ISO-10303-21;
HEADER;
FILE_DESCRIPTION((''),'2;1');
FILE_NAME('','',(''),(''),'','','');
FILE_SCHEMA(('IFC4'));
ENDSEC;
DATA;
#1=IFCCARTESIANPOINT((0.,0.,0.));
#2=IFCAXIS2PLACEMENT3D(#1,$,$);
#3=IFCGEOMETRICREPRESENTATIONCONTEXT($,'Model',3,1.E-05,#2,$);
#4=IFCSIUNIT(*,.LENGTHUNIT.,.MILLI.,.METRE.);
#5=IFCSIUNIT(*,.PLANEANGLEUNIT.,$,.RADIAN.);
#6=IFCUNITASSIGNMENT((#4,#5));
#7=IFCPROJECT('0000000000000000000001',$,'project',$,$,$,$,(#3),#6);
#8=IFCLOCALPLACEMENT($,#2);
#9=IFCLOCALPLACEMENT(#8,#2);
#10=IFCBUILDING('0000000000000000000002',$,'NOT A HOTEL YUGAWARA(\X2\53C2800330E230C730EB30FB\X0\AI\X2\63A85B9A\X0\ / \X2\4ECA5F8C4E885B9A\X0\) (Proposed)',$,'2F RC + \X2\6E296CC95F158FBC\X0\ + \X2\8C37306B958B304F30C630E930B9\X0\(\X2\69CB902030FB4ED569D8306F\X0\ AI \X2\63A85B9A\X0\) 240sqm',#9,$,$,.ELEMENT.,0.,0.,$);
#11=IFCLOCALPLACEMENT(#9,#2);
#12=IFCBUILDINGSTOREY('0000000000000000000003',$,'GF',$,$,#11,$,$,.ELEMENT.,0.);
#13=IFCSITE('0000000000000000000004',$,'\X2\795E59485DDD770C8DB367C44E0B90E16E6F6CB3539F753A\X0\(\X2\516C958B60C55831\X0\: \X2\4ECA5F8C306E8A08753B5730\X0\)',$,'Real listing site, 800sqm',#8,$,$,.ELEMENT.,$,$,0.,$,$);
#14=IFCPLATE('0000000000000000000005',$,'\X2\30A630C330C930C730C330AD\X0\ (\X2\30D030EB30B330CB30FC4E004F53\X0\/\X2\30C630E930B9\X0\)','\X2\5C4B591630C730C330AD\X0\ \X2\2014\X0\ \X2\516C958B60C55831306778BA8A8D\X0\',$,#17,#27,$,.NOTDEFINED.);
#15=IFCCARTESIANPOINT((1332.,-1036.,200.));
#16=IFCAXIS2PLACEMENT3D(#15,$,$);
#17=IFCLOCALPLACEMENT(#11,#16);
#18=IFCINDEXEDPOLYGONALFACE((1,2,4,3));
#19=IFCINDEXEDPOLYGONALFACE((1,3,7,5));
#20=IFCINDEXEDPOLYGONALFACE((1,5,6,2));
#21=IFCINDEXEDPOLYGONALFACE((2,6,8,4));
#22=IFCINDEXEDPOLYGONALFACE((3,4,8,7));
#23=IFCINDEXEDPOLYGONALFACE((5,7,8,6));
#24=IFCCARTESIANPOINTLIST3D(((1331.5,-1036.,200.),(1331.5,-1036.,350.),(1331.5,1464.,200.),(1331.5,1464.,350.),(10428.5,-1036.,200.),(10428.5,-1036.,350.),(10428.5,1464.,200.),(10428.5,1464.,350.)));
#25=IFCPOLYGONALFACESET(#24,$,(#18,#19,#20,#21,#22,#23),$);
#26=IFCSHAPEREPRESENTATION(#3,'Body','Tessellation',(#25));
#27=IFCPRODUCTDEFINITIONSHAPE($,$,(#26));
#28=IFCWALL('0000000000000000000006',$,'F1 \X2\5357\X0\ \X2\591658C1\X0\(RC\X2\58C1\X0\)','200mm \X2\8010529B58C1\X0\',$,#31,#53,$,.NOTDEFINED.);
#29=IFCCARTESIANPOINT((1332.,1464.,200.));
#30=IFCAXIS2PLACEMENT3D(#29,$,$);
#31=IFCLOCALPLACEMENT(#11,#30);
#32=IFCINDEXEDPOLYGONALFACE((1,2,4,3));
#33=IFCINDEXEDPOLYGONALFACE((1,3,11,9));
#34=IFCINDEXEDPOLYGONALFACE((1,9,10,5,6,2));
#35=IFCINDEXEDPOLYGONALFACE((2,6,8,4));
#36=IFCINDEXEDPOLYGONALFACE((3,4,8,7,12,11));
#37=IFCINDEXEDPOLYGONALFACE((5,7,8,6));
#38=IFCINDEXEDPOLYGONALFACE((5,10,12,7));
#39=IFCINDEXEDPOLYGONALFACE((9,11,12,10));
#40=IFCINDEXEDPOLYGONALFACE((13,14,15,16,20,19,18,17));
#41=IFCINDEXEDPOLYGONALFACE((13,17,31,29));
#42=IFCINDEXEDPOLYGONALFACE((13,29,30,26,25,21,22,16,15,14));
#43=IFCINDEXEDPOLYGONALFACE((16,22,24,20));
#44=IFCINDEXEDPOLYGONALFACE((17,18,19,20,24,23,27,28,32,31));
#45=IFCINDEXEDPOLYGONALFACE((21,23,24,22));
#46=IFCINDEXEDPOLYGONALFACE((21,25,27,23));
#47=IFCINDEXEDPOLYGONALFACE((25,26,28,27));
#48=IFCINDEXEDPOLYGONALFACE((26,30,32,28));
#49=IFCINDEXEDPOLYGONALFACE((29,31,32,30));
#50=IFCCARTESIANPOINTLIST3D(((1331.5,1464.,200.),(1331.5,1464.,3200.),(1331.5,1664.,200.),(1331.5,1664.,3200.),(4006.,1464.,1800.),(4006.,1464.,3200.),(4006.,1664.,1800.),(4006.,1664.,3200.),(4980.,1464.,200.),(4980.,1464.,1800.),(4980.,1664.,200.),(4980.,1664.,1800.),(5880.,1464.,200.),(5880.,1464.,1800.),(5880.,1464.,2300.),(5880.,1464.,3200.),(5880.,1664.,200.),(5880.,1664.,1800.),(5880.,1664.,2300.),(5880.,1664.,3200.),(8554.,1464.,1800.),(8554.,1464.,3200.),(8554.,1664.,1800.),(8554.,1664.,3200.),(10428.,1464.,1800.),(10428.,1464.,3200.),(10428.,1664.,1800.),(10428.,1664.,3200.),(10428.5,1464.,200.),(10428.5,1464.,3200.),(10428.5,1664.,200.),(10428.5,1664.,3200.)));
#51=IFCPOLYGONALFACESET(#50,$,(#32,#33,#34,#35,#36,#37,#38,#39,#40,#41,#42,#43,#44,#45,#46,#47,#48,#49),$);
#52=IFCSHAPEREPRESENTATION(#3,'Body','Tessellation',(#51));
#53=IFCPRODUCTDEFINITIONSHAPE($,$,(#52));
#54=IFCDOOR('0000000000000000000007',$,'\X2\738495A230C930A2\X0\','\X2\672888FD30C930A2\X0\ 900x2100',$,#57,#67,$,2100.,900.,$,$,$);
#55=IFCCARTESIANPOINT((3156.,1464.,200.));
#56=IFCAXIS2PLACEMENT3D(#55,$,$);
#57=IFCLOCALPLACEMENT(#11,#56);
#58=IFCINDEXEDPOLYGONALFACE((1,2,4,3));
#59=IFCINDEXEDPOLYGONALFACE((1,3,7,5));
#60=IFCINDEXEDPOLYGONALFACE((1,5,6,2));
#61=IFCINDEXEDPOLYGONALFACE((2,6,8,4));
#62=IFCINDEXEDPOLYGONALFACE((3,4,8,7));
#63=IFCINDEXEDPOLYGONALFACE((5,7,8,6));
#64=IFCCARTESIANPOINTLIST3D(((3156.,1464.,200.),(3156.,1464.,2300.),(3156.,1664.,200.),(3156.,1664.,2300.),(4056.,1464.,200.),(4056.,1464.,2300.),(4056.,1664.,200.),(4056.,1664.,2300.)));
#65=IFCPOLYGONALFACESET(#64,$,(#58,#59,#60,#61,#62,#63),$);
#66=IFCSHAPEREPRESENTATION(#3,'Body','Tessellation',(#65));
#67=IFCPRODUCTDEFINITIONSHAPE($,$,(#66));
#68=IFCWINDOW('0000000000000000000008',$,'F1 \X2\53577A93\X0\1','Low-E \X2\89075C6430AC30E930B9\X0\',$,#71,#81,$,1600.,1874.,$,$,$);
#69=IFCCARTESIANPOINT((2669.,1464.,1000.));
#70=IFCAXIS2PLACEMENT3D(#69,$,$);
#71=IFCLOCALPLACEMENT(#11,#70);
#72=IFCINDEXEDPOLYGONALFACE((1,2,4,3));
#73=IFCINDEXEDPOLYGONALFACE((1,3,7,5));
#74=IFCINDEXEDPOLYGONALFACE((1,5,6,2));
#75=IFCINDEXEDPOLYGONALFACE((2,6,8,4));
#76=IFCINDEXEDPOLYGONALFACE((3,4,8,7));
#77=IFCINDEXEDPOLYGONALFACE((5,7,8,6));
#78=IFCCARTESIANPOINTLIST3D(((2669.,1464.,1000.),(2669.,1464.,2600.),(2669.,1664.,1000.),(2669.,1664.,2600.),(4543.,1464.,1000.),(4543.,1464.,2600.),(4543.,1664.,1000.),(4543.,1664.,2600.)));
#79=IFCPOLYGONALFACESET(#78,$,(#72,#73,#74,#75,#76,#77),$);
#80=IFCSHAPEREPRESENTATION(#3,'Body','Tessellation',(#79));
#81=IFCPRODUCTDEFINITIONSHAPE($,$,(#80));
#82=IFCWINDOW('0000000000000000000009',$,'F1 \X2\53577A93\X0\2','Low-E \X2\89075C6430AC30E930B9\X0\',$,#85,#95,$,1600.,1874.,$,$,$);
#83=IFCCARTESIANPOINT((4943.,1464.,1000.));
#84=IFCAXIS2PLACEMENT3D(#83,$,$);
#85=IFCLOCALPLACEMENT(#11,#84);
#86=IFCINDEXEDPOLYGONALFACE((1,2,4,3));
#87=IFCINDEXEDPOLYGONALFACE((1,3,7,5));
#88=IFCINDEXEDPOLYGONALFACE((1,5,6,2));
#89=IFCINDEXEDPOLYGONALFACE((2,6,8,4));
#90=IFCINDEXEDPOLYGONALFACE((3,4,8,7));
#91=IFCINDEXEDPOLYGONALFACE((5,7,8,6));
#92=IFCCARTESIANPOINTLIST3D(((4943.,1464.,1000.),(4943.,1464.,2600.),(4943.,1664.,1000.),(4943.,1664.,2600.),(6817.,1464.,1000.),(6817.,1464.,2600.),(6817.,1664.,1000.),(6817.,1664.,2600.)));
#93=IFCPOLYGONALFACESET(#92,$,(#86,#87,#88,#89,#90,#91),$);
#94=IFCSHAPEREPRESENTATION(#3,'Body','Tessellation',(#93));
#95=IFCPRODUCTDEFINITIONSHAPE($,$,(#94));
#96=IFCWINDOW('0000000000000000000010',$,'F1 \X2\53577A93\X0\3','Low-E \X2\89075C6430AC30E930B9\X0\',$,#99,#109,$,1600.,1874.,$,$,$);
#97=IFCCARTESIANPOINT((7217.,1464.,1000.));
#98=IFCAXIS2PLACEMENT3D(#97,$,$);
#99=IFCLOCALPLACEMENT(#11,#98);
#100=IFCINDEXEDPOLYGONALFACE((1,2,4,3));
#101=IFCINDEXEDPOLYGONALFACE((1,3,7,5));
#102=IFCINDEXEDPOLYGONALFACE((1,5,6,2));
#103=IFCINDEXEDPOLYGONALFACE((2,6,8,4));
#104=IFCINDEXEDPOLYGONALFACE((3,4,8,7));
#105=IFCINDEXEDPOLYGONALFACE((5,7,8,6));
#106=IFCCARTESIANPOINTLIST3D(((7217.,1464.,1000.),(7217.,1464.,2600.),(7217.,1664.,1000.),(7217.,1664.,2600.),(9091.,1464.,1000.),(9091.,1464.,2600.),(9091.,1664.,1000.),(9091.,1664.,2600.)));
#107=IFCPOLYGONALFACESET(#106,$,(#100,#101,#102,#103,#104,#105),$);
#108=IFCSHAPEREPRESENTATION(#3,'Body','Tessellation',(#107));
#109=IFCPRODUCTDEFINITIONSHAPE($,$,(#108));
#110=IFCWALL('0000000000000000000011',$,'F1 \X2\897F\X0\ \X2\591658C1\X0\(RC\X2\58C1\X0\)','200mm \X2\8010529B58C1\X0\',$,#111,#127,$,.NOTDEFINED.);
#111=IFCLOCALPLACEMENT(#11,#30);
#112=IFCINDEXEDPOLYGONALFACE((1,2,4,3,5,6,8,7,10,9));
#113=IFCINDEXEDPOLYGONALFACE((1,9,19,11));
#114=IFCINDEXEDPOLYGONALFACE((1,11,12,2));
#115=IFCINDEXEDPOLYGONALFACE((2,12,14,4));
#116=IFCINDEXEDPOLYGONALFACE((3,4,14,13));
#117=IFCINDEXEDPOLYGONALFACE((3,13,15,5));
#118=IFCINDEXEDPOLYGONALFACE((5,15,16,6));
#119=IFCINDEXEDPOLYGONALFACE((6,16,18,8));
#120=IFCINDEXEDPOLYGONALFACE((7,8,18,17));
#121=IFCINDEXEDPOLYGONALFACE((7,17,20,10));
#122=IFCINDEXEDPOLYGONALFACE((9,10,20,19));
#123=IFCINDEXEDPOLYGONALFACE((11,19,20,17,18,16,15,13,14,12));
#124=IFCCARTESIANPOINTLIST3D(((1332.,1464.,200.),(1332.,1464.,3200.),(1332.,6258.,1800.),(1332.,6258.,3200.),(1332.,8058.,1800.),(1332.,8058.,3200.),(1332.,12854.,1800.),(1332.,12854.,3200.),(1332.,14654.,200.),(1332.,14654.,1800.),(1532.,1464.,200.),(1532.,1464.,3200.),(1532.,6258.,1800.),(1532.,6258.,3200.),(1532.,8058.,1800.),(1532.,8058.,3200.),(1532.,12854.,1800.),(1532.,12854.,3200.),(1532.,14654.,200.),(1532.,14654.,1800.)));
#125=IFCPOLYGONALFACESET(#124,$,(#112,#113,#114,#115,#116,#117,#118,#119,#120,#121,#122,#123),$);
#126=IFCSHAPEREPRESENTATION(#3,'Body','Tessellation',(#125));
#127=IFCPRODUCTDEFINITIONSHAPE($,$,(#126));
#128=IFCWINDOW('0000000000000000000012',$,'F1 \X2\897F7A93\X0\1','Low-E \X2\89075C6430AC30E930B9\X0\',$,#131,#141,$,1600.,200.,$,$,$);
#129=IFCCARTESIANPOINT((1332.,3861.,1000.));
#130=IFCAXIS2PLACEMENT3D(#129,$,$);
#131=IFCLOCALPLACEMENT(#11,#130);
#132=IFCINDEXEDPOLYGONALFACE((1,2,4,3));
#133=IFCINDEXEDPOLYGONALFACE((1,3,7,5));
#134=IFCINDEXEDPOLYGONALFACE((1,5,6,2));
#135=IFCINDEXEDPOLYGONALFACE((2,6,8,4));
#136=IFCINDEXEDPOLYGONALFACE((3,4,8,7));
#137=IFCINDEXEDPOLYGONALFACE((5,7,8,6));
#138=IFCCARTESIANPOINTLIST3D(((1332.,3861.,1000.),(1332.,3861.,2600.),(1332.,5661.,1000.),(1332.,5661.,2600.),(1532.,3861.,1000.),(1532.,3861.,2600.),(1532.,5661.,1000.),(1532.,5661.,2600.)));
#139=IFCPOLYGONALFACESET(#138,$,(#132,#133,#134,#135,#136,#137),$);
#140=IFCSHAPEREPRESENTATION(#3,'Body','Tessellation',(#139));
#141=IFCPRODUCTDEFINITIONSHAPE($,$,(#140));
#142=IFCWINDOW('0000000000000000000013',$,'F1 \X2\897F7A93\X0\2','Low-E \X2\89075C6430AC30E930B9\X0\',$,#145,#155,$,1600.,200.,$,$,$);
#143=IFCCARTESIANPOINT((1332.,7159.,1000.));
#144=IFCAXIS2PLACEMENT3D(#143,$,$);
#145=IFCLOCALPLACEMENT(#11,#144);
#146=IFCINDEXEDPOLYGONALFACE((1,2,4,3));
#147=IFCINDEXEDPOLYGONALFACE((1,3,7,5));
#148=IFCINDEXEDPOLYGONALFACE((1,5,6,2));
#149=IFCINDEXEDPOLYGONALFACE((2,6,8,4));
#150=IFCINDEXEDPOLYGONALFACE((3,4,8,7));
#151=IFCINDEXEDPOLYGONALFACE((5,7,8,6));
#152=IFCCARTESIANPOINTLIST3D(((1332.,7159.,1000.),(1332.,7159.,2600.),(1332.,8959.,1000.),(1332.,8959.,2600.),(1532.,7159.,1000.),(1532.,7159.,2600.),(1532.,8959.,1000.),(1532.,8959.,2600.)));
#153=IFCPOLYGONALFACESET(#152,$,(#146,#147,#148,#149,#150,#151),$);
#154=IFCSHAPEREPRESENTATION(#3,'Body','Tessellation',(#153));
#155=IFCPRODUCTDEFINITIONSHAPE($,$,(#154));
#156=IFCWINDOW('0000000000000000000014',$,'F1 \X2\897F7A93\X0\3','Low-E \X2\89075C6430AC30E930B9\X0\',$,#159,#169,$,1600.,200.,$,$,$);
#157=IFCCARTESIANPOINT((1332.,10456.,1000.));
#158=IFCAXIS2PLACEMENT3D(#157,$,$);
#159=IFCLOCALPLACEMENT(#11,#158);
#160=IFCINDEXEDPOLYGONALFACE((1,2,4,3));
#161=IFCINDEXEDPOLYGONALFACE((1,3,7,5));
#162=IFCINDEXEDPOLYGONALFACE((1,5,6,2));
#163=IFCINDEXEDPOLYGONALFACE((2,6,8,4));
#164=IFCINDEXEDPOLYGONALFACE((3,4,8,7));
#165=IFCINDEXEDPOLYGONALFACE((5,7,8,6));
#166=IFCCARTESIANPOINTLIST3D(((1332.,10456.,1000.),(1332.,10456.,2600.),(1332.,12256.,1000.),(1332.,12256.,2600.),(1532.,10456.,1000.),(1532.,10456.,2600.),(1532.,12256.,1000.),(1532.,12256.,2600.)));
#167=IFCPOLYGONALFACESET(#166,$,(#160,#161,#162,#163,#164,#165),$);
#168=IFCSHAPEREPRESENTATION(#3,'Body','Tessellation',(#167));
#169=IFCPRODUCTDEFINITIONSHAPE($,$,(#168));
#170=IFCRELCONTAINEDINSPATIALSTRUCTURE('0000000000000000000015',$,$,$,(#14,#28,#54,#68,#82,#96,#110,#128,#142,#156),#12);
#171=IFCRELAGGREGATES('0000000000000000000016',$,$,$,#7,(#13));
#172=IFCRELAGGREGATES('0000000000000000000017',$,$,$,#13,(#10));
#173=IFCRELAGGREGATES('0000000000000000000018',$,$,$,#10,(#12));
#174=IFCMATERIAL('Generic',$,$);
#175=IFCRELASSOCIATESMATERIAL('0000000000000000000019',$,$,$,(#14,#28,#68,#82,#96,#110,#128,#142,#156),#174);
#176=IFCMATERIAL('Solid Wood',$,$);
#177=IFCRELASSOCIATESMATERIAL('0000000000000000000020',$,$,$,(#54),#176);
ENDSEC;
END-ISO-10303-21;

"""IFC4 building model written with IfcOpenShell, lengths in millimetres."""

from ifc_helpers import new_model, si_unit, frame, frame_2d, origin, place, context, project, spatial, rectangle, extrude, material, element, fill, save


model = new_model("IFC4")

# Units and contexts
model_context = context("Model", 3, precision=1e-05, world=origin())
ifc_project = project(units=[si_unit("LENGTHUNIT", "METRE", prefix="MILLI"), si_unit("PLANEANGLEUNIT", "RADIAN")], contexts=[model_context])

# Site, building, storey
site_placement = place(None, origin())
site = spatial("IfcSite", under=ifc_project, at=site_placement, Name="神奈川県足柄下郡湯河原町(公開情報: 今後の計画地)", ObjectType="Real listing site, 800sqm", CompositionType="ELEMENT", RefElevation=0.0)
building_placement = place(site_placement, origin())
building = spatial("IfcBuilding", under=site, at=building_placement, Name="NOT A HOTEL YUGAWARA(参考モデル・AI推定 / 今後予定) (Proposed)", ObjectType="2F RC + 温泉引込 + 谷に開くテラス(構造・仕様は AI 推定) 240sqm", CompositionType="ELEMENT", ElevationOfRefHeight=0.0, ElevationOfTerrain=0.0)
storey_placement = place(building_placement, origin())
storey = spatial("IfcBuildingStorey", under=building, at=storey_placement, Name="GF", CompositionType="ELEMENT", Elevation=0.0)

# Plate
ifc_material_1 = material(Name="Generic")
plate_placement = place(storey_placement, frame((1332.0, -1036.0, 200.0)))
element("IfcPlate", 1, at=plate_placement, inside=storey, material=ifc_material_1, Name="ウッドデッキ (バルコニー一体/テラス)", Description="屋外デッキ — 公開情報で確認", PredefinedType="NOTDEFINED", context=model_context, shape_type="SweptSolid", body=[
    extrude(rectangle(XDim=9097.0, YDim=2500.0, at=frame_2d((4548.0, 1250.0))), frame((1332.0, -1036.0, 200.0)), (0.0, 0.0, 1.0), 150.0),
])

# Wall, openings, door, windows
wall_1_placement = place(storey_placement, frame((1332.0, 1464.0, 200.0)))
wall_1 = element("IfcWall", 2, at=wall_1_placement, inside=storey, material=ifc_material_1, Name="F1 南 外壁(RC壁)", Description="200mm 耐力壁", PredefinedType="NOTDEFINED", context=model_context, shape_type="SweptSolid", body=[
    extrude(rectangle(XDim=9097.0, YDim=200.0, at=frame_2d((4548.0, 100.0))), frame((1332.0, 1464.0, 200.0)), (0.0, 0.0, 1.0), 3000.0),
])
opening_1_placement = place(storey_placement, frame((3156.0, 1464.0, 200.0)))
opening_1 = element("IfcOpeningElement", 3, at=opening_1_placement, cuts=wall_1, PredefinedType="NOTDEFINED", context=model_context, shape_type="SweptSolid", body=[
    extrude(rectangle(XDim=900.0, YDim=200.0, at=frame_2d((450.0, 100.0))), frame((3156.0, 1464.0, 200.0)), (0.0, 0.0, 1.0), 2100.0),
])
opening_2_placement = place(storey_placement, frame((2669.0, 1464.0, 1000.0)))
opening_2 = element("IfcOpeningElement", 4, at=opening_2_placement, cuts=wall_1, PredefinedType="NOTDEFINED", context=model_context, shape_type="SweptSolid", body=[
    extrude(rectangle(XDim=1874.0, YDim=200.0, at=frame_2d((937.0, 100.0))), frame((2669.0, 1464.0, 1000.0)), (0.0, 0.0, 1.0), 1600.0),
])
opening_3_placement = place(storey_placement, frame((4943.0, 1464.0, 1000.0)))
opening_3 = element("IfcOpeningElement", 5, at=opening_3_placement, cuts=wall_1, PredefinedType="NOTDEFINED", context=model_context, shape_type="SweptSolid", body=[
    extrude(rectangle(XDim=1874.0, YDim=200.0, at=frame_2d((937.0, 100.0))), frame((4943.0, 1464.0, 1000.0)), (0.0, 0.0, 1.0), 1600.0),
])
opening_4_placement = place(storey_placement, frame((7217.0, 1464.0, 1000.0)))
opening_4 = element("IfcOpeningElement", 6, at=opening_4_placement, cuts=wall_1, PredefinedType="NOTDEFINED", context=model_context, shape_type="SweptSolid", body=[
    extrude(rectangle(XDim=1874.0, YDim=200.0, at=frame_2d((937.0, 100.0))), frame((7217.0, 1464.0, 1000.0)), (0.0, 0.0, 1.0), 1600.0),
])
ifc_material_2 = material(Name="Solid Wood")
door_placement = place(storey_placement, frame((3156.0, 1464.0, 200.0)))
door = element("IfcDoor", 7, at=door_placement, inside=storey, material=ifc_material_2, Name="玄関ドア", Description="木製ドア 900x2100", OverallHeight=2100.0, OverallWidth=900.0, context=model_context, shape_type="SweptSolid", body=[
    extrude(rectangle(XDim=900.0, YDim=200.0, at=frame_2d((450.0, 100.0))), frame((3156.0, 1464.0, 200.0)), (0.0, 0.0, 1.0), 2100.0),
])
fill(opening_1, door)
window_1_placement = place(storey_placement, frame((2669.0, 1464.0, 1000.0)))
window_1 = element("IfcWindow", 8, at=window_1_placement, inside=storey, material=ifc_material_1, Name="F1 南窓1", Description="Low-E 複層ガラス", OverallHeight=1600.0, OverallWidth=1874.0, context=model_context, shape_type="SweptSolid", body=[
    extrude(rectangle(XDim=1874.0, YDim=200.0, at=frame_2d((937.0, 100.0))), frame((2669.0, 1464.0, 1000.0)), (0.0, 0.0, 1.0), 1600.0),
])
fill(opening_2, window_1)
window_2_placement = place(storey_placement, frame((4943.0, 1464.0, 1000.0)))
window_2 = element("IfcWindow", 9, at=window_2_placement, inside=storey, material=ifc_material_1, Name="F1 南窓2", Description="Low-E 複層ガラス", OverallHeight=1600.0, OverallWidth=1874.0, context=model_context, shape_type="SweptSolid", body=[
    extrude(rectangle(XDim=1874.0, YDim=200.0, at=frame_2d((937.0, 100.0))), frame((4943.0, 1464.0, 1000.0)), (0.0, 0.0, 1.0), 1600.0),
])
fill(opening_3, window_2)
window_3_placement = place(storey_placement, frame((7217.0, 1464.0, 1000.0)))
window_3 = element("IfcWindow", 10, at=window_3_placement, inside=storey, material=ifc_material_1, Name="F1 南窓3", Description="Low-E 複層ガラス", OverallHeight=1600.0, OverallWidth=1874.0, context=model_context, shape_type="SweptSolid", body=[
    extrude(rectangle(XDim=1874.0, YDim=200.0, at=frame_2d((937.0, 100.0))), frame((7217.0, 1464.0, 1000.0)), (0.0, 0.0, 1.0), 1600.0),
])
fill(opening_4, window_3)

# Wall, openings, windows
wall_2_placement = place(storey_placement, frame((1332.0, 1464.0, 200.0)))
wall_2 = element("IfcWall", 11, at=wall_2_placement, inside=storey, material=ifc_material_1, Name="F1 西 外壁(RC壁)", Description="200mm 耐力壁", PredefinedType="NOTDEFINED", context=model_context, shape_type="SweptSolid", body=[
    extrude(rectangle(XDim=200.0, YDim=13190.0, at=frame_2d((100.0, 6595.0))), frame((1332.0, 1464.0, 200.0)), (0.0, 0.0, 1.0), 3000.0),
])
opening_5_placement = place(storey_placement, frame((1332.0, 3861.0, 1000.0)))
opening_5 = element("IfcOpeningElement", 12, at=opening_5_placement, cuts=wall_2, PredefinedType="NOTDEFINED", context=model_context, shape_type="SweptSolid", body=[
    extrude(rectangle(XDim=200.0, YDim=1800.0, at=frame_2d((100.0, 900.0))), frame((1332.0, 3861.0, 1000.0)), (0.0, 0.0, 1.0), 1600.0),
])
opening_6_placement = place(storey_placement, frame((1332.0, 7159.0, 1000.0)))
opening_6 = element("IfcOpeningElement", 13, at=opening_6_placement, cuts=wall_2, PredefinedType="NOTDEFINED", context=model_context, shape_type="SweptSolid", body=[
    extrude(rectangle(XDim=200.0, YDim=1800.0, at=frame_2d((100.0, 900.0))), frame((1332.0, 7159.0, 1000.0)), (0.0, 0.0, 1.0), 1600.0),
])
opening_7_placement = place(storey_placement, frame((1332.0, 10456.0, 1000.0)))
opening_7 = element("IfcOpeningElement", 14, at=opening_7_placement, cuts=wall_2, PredefinedType="NOTDEFINED", context=model_context, shape_type="SweptSolid", body=[
    extrude(rectangle(XDim=200.0, YDim=1800.0, at=frame_2d((100.0, 900.0))), frame((1332.0, 10456.0, 1000.0)), (0.0, 0.0, 1.0), 1600.0),
])
window_4_placement = place(storey_placement, frame((1332.0, 3861.0, 1000.0)))
window_4 = element("IfcWindow", 15, at=window_4_placement, inside=storey, material=ifc_material_1, Name="F1 西窓1", Description="Low-E 複層ガラス", OverallHeight=1600.0, OverallWidth=200.0, context=model_context, shape_type="SweptSolid", body=[
    extrude(rectangle(XDim=200.0, YDim=1800.0, at=frame_2d((100.0, 900.0))), frame((1332.0, 3861.0, 1000.0)), (0.0, 0.0, 1.0), 1600.0),
])
fill(opening_5, window_4)
window_5_placement = place(storey_placement, frame((1332.0, 7159.0, 1000.0)))
window_5 = element("IfcWindow", 16, at=window_5_placement, inside=storey, material=ifc_material_1, Name="F1 西窓2", Description="Low-E 複層ガラス", OverallHeight=1600.0, OverallWidth=200.0, context=model_context, shape_type="SweptSolid", body=[
    extrude(rectangle(XDim=200.0, YDim=1800.0, at=frame_2d((100.0, 900.0))), frame((1332.0, 7159.0, 1000.0)), (0.0, 0.0, 1.0), 1600.0),
])
fill(opening_6, window_5)
window_6_placement = place(storey_placement, frame((1332.0, 10456.0, 1000.0)))
window_6 = element("IfcWindow", 17, at=window_6_placement, inside=storey, material=ifc_material_1, Name="F1 西窓3", Description="Low-E 複層ガラス", OverallHeight=1600.0, OverallWidth=200.0, context=model_context, shape_type="SweptSolid", body=[
    extrude(rectangle(XDim=200.0, YDim=1800.0, at=frame_2d((100.0, 900.0))), frame((1332.0, 10456.0, 1000.0)), (0.0, 0.0, 1.0), 1600.0),
])
fill(opening_7, window_6)

save(model, "model.ifc")
